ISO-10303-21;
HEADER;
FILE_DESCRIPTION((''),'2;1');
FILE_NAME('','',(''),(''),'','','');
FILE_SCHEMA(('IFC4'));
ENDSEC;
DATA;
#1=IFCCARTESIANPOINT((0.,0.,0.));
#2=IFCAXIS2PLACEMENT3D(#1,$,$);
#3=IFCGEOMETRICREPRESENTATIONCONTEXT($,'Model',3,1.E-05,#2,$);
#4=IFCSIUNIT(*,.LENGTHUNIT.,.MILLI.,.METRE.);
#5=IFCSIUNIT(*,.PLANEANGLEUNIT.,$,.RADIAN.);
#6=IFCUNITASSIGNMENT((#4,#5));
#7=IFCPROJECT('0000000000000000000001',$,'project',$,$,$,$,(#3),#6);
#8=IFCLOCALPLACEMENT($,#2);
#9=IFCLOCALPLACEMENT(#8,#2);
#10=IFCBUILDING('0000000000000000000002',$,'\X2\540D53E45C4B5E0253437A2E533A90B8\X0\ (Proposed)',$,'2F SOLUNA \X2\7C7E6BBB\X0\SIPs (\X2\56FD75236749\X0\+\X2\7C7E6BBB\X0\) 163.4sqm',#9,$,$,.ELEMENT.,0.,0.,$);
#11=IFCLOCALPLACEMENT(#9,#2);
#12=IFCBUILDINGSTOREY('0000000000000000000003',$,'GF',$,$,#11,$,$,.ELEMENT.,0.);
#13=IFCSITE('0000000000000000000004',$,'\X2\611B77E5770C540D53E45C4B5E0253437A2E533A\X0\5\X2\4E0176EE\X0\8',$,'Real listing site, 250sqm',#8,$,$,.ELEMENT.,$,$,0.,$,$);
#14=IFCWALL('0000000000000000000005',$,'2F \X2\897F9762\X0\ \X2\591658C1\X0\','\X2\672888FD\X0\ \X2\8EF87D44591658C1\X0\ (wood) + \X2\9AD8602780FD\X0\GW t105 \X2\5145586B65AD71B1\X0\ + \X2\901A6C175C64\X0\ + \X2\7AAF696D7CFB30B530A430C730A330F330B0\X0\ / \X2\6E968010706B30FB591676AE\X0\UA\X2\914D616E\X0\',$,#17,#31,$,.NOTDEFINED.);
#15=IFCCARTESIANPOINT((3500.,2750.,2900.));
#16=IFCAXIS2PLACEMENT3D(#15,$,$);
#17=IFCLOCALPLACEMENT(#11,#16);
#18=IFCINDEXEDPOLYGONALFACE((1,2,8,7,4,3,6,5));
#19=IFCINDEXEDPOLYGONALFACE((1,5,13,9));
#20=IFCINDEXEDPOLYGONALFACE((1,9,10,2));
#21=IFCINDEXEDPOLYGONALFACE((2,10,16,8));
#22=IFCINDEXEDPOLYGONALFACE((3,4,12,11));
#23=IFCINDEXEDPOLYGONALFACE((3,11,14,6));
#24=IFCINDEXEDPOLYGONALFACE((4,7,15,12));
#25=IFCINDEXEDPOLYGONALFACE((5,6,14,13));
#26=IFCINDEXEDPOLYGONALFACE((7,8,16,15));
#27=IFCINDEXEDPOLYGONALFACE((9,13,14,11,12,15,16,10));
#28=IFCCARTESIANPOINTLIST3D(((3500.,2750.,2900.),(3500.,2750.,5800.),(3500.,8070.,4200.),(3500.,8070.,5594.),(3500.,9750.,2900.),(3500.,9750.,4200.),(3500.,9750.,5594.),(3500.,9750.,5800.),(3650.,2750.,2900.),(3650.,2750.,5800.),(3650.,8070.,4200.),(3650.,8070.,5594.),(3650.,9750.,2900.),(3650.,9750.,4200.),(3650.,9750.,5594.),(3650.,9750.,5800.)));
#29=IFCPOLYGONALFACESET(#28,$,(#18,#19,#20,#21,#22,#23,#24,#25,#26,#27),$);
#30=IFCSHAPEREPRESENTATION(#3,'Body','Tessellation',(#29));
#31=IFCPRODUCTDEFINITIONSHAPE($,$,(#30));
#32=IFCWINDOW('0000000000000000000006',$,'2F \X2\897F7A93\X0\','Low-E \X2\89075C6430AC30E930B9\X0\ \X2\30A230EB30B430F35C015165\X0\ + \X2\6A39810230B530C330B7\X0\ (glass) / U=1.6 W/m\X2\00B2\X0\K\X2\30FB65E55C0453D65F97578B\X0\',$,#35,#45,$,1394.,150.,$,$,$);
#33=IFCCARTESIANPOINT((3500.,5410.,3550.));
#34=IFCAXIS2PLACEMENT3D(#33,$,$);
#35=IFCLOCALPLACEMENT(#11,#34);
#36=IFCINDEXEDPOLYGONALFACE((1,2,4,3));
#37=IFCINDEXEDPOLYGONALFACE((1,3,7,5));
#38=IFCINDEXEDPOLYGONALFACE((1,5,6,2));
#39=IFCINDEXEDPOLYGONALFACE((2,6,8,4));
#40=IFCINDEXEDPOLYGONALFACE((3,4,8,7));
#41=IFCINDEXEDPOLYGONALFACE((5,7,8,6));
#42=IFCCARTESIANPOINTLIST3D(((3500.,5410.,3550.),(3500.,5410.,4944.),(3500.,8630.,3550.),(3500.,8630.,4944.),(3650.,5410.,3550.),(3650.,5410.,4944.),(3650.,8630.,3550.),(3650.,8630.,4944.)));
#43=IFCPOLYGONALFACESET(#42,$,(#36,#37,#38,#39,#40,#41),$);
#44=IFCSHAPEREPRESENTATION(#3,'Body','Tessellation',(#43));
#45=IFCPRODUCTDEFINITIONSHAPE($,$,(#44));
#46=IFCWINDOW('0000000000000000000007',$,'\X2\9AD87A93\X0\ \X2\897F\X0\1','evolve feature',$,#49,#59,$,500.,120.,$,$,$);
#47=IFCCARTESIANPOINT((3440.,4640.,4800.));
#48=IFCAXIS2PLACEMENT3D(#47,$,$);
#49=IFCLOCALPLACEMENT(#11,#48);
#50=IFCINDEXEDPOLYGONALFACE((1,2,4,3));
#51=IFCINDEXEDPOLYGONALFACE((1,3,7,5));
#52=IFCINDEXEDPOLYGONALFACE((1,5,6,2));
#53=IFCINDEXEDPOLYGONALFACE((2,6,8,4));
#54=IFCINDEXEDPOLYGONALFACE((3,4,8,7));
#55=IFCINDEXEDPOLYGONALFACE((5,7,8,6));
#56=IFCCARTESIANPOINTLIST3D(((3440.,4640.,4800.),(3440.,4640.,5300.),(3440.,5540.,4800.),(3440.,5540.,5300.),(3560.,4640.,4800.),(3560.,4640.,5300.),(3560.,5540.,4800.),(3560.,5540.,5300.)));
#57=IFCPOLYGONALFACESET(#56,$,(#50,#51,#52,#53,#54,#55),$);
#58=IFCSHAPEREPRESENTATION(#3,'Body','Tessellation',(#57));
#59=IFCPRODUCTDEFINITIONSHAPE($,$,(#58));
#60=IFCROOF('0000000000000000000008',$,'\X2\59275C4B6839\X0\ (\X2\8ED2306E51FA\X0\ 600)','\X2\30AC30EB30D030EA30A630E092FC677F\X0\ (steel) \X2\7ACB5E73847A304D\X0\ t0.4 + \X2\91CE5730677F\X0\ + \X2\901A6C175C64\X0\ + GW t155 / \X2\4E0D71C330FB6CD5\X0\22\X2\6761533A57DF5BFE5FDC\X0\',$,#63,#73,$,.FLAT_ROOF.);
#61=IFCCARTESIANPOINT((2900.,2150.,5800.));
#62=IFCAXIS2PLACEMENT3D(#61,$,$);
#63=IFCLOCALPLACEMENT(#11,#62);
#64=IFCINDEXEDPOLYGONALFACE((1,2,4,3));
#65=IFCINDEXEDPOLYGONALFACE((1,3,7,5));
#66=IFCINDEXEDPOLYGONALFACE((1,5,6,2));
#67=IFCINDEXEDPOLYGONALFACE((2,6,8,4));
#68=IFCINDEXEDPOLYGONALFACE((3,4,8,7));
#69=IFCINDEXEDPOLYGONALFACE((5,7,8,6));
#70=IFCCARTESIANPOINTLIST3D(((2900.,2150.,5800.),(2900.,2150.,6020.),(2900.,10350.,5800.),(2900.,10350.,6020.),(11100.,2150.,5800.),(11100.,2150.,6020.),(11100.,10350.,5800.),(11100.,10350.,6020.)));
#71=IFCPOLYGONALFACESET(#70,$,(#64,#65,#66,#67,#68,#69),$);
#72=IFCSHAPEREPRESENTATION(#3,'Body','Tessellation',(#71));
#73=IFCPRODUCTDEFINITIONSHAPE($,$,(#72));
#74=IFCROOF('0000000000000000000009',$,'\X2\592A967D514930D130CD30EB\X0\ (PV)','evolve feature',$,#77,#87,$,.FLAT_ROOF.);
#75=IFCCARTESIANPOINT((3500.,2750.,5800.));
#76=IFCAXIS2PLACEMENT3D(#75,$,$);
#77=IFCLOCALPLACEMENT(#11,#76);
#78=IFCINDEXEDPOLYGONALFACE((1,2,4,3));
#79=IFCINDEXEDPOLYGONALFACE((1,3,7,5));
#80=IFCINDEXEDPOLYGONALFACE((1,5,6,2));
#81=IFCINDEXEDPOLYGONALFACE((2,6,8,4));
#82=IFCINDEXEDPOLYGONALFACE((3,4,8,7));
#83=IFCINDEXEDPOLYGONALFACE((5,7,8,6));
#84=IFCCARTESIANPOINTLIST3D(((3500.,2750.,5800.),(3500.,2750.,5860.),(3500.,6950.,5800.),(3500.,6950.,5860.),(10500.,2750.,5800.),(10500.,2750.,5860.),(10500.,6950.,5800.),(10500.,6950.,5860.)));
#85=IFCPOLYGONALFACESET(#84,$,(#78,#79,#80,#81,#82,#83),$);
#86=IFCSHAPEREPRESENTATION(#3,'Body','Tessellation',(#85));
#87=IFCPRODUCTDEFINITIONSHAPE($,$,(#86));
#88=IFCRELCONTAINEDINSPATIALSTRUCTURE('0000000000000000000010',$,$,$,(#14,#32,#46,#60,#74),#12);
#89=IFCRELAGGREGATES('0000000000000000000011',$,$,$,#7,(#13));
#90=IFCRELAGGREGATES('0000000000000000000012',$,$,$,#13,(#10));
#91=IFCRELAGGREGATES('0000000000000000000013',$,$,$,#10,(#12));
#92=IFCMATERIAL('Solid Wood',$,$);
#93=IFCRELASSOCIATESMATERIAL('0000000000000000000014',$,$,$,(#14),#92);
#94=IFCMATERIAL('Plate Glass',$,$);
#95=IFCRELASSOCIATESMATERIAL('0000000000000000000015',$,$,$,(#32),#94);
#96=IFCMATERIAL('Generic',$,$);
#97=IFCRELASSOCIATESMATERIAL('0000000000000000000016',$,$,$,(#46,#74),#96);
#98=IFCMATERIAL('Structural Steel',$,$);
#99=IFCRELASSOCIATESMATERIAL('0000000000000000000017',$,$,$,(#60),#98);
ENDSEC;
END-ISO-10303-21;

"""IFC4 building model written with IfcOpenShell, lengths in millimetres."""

from ifc_helpers import new_model, si_unit, frame, frame_2d, origin, place, context, project, spatial, rectangle, extrude, material, element, fill, save


model = new_model("IFC4")

# Units and contexts
model_context = context("Model", 3, precision=1e-05, world=origin())
ifc_project = project(units=[si_unit("LENGTHUNIT", "METRE", prefix="MILLI"), si_unit("PLANEANGLEUNIT", "RADIAN")], contexts=[model_context])

# Site, building, storey
site_placement = place(None, origin())
site = spatial("IfcSite", under=ifc_project, at=site_placement, Name="愛知県名古屋市千種区5丁目8", ObjectType="Real listing site, 250sqm", CompositionType="ELEMENT", RefElevation=0.0)
building_placement = place(site_placement, origin())
building = spatial("IfcBuilding", under=site, at=building_placement, Name="名古屋市千種区邸 (Proposed)", ObjectType="2F SOLUNA 籾殻SIPs (国産杉+籾殻) 163.4sqm", CompositionType="ELEMENT", ElevationOfRefHeight=0.0, ElevationOfTerrain=0.0)
storey_placement = place(building_placement, origin())
storey = spatial("IfcBuildingStorey", under=building, at=storey_placement, Name="GF", CompositionType="ELEMENT", Elevation=0.0)

# Shared definitions
ifc_material_1 = material(Name="Solid Wood")
ifc_material_2 = material(Name="Generic")

# Shared definitions
ifc_material_3 = material(Name="Plate Glass")

# Wall, openings, windows
wall_1_placement = place(storey_placement, frame((3500.0, 2750.0, 2900.0)))
wall_1 = element("IfcWall", 1, at=wall_1_placement, inside=storey, material=ifc_material_1, Name="2F 西面 外壁", Description="木製 軸組外壁 (wood) + 高性能GW t105 充填断熱 + 通気層 + 窯業系サイディング / 準耐火・外皮UA配慮", PredefinedType="NOTDEFINED", context=model_context, shape_type="SweptSolid", body=[
    extrude(rectangle(XDim=150.0, YDim=7000.0, at=frame_2d((75.0, 3500.0))), frame((3500.0, 2750.0, 2900.0)), (0.0, 0.0, 1.0), 2900.0),
])
opening_1_placement = place(storey_placement, frame((3500.0, 5410.0, 3550.0)))
opening_1 = element("IfcOpeningElement", 2, at=opening_1_placement, cuts=wall_1, PredefinedType="NOTDEFINED", context=model_context, shape_type="SweptSolid", body=[
    extrude(rectangle(XDim=150.0, YDim=3220.0, at=frame_2d((75.0, 1610.0))), frame((3500.0, 5410.0, 3550.0)), (0.0, 0.0, 1.0), 1394.0),
])
opening_2_placement = place(storey_placement, frame((3440.0, 4640.0, 4800.0)))
opening_2 = element("IfcOpeningElement", 3, at=opening_2_placement, cuts=wall_1, PredefinedType="NOTDEFINED", context=model_context, shape_type="SweptSolid", body=[
    extrude(rectangle(XDim=120.0, YDim=900.0, at=frame_2d((60.0, 450.0))), frame((3440.0, 4640.0, 4800.0)), (0.0, 0.0, 1.0), 500.0),
])
window_1_placement = place(storey_placement, frame((3500.0, 5410.0, 3550.0)))
window_1 = element("IfcWindow", 4, at=window_1_placement, inside=storey, material=ifc_material_3, Name="2F 西窓", Description="Low-E 複層ガラス アルゴン封入 + 樹脂サッシ (glass) / U=1.6 W/m²K・日射取得型", OverallHeight=1394.0, OverallWidth=150.0, context=model_context, shape_type="SweptSolid", body=[
    extrude(rectangle(XDim=150.0, YDim=3220.0, at=frame_2d((75.0, 1610.0))), frame((3500.0, 5410.0, 3550.0)), (0.0, 0.0, 1.0), 1394.0),
])
fill(opening_1, window_1)
window_2_placement = place(storey_placement, frame((3440.0, 4640.0, 4800.0)))
window_2 = element("IfcWindow", 5, at=window_2_placement, inside=storey, material=ifc_material_2, Name="高窓 西1", Description="evolve feature", OverallHeight=500.0, OverallWidth=120.0, context=model_context, shape_type="SweptSolid", body=[
    extrude(rectangle(XDim=120.0, YDim=900.0, at=frame_2d((60.0, 450.0))), frame((3440.0, 4640.0, 4800.0)), (0.0, 0.0, 1.0), 500.0),
])
fill(opening_2, window_2)

# Roofs
ifc_material_4 = material(Name="Structural Steel")
roof_1_placement = place(storey_placement, frame((2900.0, 2150.0, 5800.0)))
element("IfcRoof", 6, at=roof_1_placement, inside=storey, material=ifc_material_4, Name="大屋根 (軒の出 600)", Description="ガルバリウム鋼板 (steel) 立平葺き t0.4 + 野地板 + 通気層 + GW t155 / 不燃・法22条区域対応", PredefinedType="FLAT_ROOF", context=model_context, shape_type="SweptSolid", body=[
    extrude(rectangle(XDim=8200.0, YDim=8200.0, at=frame_2d((4100.0, 4100.0))), frame((2900.0, 2150.0, 5800.0)), (0.0, 0.0, 1.0), 220.0),
])
roof_2_placement = place(storey_placement, frame((3500.0, 2750.0, 5800.0)))
element("IfcRoof", 7, at=roof_2_placement, inside=storey, material=ifc_material_2, Name="太陽光パネル (PV)", Description="evolve feature", PredefinedType="FLAT_ROOF", context=model_context, shape_type="SweptSolid", body=[
    extrude(rectangle(XDim=7000.0, YDim=4200.0, at=frame_2d((3500.0, 2100.0))), frame((3500.0, 2750.0, 5800.0)), (0.0, 0.0, 1.0), 60.0),
])

save(model, "model.ifc")
